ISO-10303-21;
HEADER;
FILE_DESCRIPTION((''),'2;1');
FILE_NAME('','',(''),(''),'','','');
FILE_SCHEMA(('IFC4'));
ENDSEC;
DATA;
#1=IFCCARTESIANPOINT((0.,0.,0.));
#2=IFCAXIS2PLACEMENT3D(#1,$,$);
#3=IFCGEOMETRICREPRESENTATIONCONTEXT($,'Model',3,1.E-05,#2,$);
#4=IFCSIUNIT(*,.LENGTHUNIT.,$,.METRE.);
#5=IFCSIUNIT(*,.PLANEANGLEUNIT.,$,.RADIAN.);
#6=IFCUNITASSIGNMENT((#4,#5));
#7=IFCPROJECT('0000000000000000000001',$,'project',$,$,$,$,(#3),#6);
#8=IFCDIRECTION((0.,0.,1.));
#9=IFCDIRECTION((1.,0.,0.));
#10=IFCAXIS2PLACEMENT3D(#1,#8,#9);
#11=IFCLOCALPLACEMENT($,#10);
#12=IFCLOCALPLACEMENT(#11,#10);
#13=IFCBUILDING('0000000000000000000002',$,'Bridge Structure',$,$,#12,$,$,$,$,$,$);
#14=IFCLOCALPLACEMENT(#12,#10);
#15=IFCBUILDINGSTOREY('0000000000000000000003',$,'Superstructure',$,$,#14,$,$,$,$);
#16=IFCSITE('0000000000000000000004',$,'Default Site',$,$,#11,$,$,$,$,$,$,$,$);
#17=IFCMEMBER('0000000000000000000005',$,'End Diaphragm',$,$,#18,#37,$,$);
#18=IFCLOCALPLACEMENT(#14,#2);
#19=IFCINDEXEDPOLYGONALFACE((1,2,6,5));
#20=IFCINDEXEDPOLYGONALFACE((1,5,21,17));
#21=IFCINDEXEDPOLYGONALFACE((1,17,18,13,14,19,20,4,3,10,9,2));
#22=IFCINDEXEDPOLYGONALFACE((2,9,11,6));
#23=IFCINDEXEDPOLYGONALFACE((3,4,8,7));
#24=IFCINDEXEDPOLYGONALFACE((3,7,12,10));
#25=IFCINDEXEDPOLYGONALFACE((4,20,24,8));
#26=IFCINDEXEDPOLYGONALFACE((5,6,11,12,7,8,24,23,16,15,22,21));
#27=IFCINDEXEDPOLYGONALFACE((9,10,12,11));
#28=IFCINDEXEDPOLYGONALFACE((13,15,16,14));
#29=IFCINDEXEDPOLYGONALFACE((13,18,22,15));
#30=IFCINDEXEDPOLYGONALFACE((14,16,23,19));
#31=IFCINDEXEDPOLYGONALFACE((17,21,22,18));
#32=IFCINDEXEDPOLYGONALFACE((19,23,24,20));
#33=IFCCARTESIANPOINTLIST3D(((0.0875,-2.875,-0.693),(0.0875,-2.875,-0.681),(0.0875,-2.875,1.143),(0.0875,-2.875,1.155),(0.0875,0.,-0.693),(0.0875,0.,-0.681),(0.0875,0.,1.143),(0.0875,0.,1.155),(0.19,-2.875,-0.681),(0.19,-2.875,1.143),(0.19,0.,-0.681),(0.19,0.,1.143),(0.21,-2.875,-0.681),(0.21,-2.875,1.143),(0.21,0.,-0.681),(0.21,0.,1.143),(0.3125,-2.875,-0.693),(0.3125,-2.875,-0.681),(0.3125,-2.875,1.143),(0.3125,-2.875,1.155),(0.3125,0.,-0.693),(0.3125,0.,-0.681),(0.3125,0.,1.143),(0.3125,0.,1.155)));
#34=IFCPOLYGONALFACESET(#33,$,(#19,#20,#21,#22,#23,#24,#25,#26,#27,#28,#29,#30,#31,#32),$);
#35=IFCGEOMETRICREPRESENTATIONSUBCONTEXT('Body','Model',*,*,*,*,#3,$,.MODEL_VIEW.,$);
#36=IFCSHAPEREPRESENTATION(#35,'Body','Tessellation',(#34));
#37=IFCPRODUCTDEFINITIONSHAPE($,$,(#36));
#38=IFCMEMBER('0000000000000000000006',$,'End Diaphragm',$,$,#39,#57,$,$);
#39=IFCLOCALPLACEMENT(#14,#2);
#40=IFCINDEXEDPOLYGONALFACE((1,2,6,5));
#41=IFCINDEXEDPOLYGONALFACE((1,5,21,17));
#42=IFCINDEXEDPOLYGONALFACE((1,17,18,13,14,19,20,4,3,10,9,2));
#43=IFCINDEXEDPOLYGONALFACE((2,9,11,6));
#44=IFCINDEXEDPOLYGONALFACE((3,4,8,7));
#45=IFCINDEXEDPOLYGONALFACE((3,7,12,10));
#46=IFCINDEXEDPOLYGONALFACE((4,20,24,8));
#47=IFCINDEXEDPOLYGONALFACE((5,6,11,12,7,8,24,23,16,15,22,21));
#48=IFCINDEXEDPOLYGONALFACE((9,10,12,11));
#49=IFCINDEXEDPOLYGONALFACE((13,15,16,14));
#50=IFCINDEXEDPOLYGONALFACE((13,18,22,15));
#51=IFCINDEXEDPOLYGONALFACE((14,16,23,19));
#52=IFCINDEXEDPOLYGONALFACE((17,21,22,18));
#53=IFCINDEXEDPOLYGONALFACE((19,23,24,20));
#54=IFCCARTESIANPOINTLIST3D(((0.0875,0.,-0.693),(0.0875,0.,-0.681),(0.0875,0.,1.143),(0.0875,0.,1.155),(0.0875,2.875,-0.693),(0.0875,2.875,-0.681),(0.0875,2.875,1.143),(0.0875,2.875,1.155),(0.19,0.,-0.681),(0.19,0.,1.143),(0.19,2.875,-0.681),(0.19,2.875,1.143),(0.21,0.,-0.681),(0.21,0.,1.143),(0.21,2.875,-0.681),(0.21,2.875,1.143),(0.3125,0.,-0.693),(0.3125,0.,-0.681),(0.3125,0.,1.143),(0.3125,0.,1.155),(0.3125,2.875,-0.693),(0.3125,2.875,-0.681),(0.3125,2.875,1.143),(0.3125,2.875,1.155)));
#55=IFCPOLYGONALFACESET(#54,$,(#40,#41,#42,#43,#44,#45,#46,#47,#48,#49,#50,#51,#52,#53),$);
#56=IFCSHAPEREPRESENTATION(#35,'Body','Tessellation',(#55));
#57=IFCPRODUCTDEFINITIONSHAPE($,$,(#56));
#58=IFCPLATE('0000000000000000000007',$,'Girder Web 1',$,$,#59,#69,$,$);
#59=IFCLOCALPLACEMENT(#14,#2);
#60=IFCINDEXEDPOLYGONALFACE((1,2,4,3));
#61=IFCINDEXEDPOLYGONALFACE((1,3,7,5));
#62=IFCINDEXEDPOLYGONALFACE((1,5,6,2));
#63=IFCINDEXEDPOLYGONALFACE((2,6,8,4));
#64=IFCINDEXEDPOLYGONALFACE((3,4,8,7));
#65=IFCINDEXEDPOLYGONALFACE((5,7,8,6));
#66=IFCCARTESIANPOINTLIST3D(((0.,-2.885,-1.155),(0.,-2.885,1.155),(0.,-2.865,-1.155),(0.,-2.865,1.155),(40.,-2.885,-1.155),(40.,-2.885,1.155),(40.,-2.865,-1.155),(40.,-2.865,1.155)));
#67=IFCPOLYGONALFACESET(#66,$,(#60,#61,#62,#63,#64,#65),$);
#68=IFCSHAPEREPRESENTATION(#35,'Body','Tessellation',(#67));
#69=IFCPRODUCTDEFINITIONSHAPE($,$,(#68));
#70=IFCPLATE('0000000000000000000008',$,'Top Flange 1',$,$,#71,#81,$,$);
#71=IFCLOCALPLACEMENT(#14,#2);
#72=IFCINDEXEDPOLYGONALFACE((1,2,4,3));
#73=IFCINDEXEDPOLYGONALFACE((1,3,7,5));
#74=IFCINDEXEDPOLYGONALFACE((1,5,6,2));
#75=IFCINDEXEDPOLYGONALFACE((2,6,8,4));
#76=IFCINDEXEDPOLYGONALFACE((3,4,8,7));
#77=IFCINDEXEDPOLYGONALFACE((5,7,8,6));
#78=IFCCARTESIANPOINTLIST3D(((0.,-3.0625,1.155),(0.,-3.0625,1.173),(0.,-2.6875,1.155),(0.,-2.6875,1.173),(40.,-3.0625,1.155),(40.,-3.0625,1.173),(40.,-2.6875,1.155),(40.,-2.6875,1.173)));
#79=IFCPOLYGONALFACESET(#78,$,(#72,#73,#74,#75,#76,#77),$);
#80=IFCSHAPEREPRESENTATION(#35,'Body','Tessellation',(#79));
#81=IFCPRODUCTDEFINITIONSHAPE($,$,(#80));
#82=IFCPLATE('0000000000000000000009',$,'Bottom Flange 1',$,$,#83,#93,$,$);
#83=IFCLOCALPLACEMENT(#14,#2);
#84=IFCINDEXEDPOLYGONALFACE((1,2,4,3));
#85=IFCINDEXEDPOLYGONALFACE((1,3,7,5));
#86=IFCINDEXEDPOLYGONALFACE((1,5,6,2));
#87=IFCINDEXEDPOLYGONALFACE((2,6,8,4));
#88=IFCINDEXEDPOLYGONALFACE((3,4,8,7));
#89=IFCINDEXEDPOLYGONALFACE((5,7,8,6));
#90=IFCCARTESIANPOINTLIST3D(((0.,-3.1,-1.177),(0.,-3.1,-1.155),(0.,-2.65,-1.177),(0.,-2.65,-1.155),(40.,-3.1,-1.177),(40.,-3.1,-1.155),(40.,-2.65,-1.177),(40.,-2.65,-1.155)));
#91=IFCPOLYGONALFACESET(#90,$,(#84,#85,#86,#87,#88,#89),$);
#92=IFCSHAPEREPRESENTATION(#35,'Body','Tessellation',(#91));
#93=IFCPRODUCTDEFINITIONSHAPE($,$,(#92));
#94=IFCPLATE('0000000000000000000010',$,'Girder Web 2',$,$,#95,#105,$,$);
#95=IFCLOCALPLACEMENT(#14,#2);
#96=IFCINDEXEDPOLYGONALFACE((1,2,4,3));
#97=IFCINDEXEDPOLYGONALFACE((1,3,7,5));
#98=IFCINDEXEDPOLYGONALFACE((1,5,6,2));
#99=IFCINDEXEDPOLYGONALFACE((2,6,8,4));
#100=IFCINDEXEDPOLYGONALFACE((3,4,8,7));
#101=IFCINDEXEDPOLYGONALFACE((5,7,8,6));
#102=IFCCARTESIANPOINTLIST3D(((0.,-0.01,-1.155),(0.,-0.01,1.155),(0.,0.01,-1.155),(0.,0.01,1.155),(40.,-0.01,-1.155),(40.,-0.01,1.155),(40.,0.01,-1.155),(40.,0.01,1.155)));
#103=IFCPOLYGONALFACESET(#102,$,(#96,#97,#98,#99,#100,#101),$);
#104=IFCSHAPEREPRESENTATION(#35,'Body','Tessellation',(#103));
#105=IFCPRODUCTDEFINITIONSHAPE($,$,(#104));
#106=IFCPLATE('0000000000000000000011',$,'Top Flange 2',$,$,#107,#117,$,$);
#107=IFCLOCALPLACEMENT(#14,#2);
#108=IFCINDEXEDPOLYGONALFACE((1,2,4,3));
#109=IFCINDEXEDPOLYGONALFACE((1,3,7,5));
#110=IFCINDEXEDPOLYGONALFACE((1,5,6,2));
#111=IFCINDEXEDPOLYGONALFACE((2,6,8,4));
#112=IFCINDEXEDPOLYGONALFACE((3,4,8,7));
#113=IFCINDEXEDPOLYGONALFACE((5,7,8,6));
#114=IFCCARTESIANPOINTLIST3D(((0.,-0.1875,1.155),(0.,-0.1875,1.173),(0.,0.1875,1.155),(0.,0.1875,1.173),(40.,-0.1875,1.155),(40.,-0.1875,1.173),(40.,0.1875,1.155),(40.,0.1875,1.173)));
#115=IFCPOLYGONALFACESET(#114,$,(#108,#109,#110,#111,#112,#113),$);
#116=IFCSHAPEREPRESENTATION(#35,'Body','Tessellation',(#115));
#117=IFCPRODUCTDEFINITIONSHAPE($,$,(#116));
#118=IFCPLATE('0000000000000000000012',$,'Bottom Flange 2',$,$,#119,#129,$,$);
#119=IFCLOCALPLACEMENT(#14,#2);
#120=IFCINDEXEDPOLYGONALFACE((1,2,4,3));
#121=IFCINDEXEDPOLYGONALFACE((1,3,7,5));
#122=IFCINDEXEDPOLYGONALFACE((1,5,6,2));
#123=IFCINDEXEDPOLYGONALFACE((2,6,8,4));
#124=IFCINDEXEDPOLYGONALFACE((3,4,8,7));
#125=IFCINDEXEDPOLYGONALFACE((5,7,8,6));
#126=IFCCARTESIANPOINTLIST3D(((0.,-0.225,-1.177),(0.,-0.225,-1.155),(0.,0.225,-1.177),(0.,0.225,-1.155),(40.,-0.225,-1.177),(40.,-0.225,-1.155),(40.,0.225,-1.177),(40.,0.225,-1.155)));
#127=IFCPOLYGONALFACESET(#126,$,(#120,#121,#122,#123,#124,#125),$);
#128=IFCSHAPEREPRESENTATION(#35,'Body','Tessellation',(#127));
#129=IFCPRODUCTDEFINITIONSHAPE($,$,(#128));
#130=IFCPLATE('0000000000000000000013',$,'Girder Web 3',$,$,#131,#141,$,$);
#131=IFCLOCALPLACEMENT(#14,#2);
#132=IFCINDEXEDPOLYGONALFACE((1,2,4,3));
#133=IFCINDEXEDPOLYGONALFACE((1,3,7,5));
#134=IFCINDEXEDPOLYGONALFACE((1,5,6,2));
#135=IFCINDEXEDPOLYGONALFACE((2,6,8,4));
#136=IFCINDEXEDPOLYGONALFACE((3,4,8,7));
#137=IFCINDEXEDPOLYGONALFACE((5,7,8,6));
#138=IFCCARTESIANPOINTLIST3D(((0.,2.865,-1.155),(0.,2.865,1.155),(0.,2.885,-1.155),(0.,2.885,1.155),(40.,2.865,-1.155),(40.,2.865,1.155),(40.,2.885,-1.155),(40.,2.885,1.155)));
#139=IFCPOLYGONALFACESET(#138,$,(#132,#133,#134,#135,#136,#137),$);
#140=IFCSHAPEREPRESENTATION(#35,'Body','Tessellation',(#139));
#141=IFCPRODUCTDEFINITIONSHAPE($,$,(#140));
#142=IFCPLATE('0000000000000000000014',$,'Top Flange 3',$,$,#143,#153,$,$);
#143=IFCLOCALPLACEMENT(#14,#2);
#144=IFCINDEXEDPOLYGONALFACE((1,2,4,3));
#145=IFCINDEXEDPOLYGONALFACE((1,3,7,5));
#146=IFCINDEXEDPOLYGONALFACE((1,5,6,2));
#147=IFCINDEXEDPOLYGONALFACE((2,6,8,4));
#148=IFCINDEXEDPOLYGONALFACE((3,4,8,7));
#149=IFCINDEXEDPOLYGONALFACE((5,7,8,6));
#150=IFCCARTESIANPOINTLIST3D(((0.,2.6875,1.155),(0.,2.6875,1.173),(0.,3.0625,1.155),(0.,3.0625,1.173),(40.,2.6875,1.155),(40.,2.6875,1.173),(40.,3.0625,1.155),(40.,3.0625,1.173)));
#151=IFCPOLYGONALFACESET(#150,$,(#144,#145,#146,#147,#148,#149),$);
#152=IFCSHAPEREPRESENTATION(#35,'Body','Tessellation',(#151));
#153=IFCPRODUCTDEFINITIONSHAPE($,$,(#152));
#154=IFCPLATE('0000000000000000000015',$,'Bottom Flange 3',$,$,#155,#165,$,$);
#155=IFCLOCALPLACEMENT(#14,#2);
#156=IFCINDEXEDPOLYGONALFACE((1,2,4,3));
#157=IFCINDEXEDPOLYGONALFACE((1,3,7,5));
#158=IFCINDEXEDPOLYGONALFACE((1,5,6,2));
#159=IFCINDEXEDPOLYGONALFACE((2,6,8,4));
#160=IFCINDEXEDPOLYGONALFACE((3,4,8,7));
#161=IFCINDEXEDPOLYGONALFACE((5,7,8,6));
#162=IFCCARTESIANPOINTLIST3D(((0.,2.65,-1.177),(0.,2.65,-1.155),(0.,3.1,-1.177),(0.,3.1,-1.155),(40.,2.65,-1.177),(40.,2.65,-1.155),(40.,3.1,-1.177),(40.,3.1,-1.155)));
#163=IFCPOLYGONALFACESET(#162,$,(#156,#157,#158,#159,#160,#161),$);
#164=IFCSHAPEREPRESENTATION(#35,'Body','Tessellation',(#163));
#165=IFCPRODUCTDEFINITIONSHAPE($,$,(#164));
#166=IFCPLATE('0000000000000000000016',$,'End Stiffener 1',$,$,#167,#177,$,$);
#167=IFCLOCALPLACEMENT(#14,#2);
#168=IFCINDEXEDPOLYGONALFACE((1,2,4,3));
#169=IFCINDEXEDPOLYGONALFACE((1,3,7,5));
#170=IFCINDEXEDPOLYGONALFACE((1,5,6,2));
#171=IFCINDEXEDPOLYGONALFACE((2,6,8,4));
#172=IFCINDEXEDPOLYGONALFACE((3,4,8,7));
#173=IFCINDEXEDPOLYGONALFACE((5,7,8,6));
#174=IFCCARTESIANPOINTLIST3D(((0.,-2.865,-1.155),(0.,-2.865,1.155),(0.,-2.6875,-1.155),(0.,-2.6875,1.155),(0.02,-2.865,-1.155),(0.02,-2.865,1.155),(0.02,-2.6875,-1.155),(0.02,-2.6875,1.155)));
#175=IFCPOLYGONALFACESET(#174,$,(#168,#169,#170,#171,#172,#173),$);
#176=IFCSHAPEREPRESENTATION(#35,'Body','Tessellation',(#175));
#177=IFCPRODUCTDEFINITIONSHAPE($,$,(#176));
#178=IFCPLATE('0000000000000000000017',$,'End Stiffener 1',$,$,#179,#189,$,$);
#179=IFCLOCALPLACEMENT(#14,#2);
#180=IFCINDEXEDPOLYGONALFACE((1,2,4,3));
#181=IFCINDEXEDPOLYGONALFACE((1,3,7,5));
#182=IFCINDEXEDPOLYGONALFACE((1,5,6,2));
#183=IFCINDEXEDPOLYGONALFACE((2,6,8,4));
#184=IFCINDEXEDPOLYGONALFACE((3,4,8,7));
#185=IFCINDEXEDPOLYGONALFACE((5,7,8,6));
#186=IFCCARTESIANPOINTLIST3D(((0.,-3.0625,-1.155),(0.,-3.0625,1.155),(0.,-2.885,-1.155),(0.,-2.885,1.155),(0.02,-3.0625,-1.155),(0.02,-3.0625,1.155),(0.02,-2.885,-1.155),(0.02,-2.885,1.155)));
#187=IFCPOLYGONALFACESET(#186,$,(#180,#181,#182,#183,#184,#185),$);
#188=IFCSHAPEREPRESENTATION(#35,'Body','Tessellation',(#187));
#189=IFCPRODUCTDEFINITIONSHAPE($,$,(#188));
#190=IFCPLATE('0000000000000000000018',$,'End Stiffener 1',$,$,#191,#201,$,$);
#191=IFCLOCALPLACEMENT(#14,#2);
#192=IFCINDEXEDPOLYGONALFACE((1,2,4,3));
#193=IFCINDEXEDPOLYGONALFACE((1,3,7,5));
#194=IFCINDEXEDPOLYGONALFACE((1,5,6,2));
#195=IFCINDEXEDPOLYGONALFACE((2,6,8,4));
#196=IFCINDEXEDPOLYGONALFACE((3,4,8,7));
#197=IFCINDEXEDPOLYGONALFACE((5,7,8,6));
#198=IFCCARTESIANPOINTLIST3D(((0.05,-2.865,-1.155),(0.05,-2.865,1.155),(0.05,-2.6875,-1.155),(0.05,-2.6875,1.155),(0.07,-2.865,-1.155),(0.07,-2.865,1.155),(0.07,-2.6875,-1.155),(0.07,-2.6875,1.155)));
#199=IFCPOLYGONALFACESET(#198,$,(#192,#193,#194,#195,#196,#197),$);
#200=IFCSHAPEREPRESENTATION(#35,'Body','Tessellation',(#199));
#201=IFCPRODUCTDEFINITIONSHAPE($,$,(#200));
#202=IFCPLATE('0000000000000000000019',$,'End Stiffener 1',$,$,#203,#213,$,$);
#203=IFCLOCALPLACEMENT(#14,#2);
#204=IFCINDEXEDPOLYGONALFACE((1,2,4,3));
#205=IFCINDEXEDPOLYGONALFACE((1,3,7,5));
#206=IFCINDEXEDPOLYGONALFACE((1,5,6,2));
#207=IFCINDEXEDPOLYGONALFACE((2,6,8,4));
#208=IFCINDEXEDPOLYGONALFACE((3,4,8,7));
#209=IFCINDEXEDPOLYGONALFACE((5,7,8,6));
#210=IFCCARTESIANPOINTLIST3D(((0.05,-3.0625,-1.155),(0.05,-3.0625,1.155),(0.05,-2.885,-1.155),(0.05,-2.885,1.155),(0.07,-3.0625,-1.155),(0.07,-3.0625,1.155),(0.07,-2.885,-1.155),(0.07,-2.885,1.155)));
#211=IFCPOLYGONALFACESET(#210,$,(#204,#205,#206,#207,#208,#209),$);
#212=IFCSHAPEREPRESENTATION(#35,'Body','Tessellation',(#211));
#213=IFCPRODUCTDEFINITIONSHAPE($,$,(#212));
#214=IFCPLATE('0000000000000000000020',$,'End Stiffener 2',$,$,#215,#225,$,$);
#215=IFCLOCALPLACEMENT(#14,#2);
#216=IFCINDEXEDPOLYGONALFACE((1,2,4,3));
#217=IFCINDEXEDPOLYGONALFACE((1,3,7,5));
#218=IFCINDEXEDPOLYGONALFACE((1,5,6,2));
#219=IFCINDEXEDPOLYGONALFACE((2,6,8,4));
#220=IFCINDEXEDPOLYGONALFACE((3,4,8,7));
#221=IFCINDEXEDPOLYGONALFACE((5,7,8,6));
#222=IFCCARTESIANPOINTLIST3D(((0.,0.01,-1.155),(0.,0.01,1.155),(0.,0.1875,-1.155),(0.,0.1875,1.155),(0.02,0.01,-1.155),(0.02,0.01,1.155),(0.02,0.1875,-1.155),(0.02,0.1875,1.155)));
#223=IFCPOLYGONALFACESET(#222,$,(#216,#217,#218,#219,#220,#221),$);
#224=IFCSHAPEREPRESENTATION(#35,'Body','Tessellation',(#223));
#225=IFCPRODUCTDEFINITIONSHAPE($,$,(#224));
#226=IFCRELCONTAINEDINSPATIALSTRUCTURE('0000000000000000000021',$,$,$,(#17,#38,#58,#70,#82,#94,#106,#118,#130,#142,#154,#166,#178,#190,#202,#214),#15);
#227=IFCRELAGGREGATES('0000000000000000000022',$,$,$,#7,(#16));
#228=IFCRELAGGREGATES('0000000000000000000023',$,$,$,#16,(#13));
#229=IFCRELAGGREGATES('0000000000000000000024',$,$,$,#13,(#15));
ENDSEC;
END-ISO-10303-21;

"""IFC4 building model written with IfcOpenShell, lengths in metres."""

from ifc_helpers import new_model, si_unit, frame, origin, origin_with_axes, origin_2d_with_axis, place, context, subcontext, project, spatial, rectangle, i_section, extrude, element, save


model = new_model("IFC4")

# Units and contexts
model_context = context("Model", 3, precision=1e-05, world=origin())
body_context = subcontext(model_context, "Body", "Model", "MODEL_VIEW")
ifc_project = project(units=[si_unit("LENGTHUNIT", "METRE"), si_unit("PLANEANGLEUNIT", "RADIAN")], contexts=[model_context])

# Site, building, storey
site_placement = place(None, origin_with_axes())
site = spatial("IfcSite", under=ifc_project, at=site_placement, Name="Default Site")
building_placement = place(site_placement, origin_with_axes())
building = spatial("IfcBuilding", under=site, at=building_placement, Name="Bridge Structure")
storey_placement = place(building_placement, origin_with_axes())
storey = spatial("IfcBuildingStorey", under=building, at=storey_placement, Name="Superstructure")

# Members
for number, where, z_axis, x_axis, name in (
    (1, (0.2, -2.875, 0.231), (0.0, 1.0, 0.0), (-1.0, 0.0, 0.0), "End Diaphragm"),
    (2, (0.2, 0.0, 0.231), (0.0, 1.0, 0.0), (-1.0, 0.0, 0.0), "End Diaphragm"),
):
    element("IfcMember", number, at=place(storey_placement, frame(where, z_axis=z_axis, x_axis=x_axis)), inside=storey, Name=name, context=body_context, shape_type="SweptSolid", body=[
        extrude(i_section(OverallWidth=0.225, OverallDepth=1.848, WebThickness=0.02, FlangeThickness=0.012, at=origin_2d_with_axis()), origin_with_axes(), (0.0, 0.0, 1.0), 2.875),
    ])

# Plates
plate_1_placement = place(storey_placement, frame((0.0, -2.875, 0.0), z_axis=(1.0, 0.0, 0.0), x_axis=(0.0, 1.0, 0.0)))
element("IfcPlate", 3, at=plate_1_placement, inside=storey, Name="Girder Web 1", context=body_context, shape_type="SweptSolid", body=[
    extrude(rectangle(XDim=0.02, YDim=2.31, at=origin_2d_with_axis()), origin_with_axes(), (0.0, 0.0, 1.0), 40.0),
])
plate_2_placement = place(storey_placement, frame((0.0, -2.875, 1.164), z_axis=(1.0, 0.0, 0.0), x_axis=(0.0, 1.0, 0.0)))
element("IfcPlate", 4, at=plate_2_placement, inside=storey, Name="Top Flange 1", context=body_context, shape_type="SweptSolid", body=[
    extrude(rectangle(XDim=0.375, YDim=0.018, at=origin_2d_with_axis()), origin_with_axes(), (0.0, 0.0, 1.0), 40.0),
])
plate_3_placement = place(storey_placement, frame((0.0, -2.875, -1.166), z_axis=(1.0, 0.0, 0.0), x_axis=(0.0, 1.0, 0.0)))
element("IfcPlate", 5, at=plate_3_placement, inside=storey, Name="Bottom Flange 1", context=body_context, shape_type="SweptSolid", body=[
    extrude(rectangle(XDim=0.45, YDim=0.022, at=origin_2d_with_axis()), origin_with_axes(), (0.0, 0.0, 1.0), 40.0),
])
plate_4_placement = place(storey_placement, frame((0.0, 0.0, 0.0), z_axis=(1.0, 0.0, 0.0), x_axis=(0.0, 1.0, 0.0)))
element("IfcPlate", 6, at=plate_4_placement, inside=storey, Name="Girder Web 2", context=body_context, shape_type="SweptSolid", body=[
    extrude(rectangle(XDim=0.02, YDim=2.31, at=origin_2d_with_axis()), origin_with_axes(), (0.0, 0.0, 1.0), 40.0),
])
plate_5_placement = place(storey_placement, frame((0.0, 0.0, 1.164), z_axis=(1.0, 0.0, 0.0), x_axis=(0.0, 1.0, 0.0)))
element("IfcPlate", 7, at=plate_5_placement, inside=storey, Name="Top Flange 2", context=body_context, shape_type="SweptSolid", body=[
    extrude(rectangle(XDim=0.375, YDim=0.018, at=origin_2d_with_axis()), origin_with_axes(), (0.0, 0.0, 1.0), 40.0),
])
plate_6_placement = place(storey_placement, frame((0.0, 0.0, -1.166), z_axis=(1.0, 0.0, 0.0), x_axis=(0.0, 1.0, 0.0)))
element("IfcPlate", 8, at=plate_6_placement, inside=storey, Name="Bottom Flange 2", context=body_context, shape_type="SweptSolid", body=[
    extrude(rectangle(XDim=0.45, YDim=0.022, at=origin_2d_with_axis()), origin_with_axes(), (0.0, 0.0, 1.0), 40.0),
])
plate_7_placement = place(storey_placement, frame((0.0, 2.875, 0.0), z_axis=(1.0, 0.0, 0.0), x_axis=(0.0, 1.0, 0.0)))
element("IfcPlate", 9, at=plate_7_placement, inside=storey, Name="Girder Web 3", context=body_context, shape_type="SweptSolid", body=[
    extrude(rectangle(XDim=0.02, YDim=2.31, at=origin_2d_with_axis()), origin_with_axes(), (0.0, 0.0, 1.0), 40.0),
])
plate_8_placement = place(storey_placement, frame((0.0, 2.875, 1.164), z_axis=(1.0, 0.0, 0.0), x_axis=(0.0, 1.0, 0.0)))
element("IfcPlate", 10, at=plate_8_placement, inside=storey, Name="Top Flange 3", context=body_context, shape_type="SweptSolid", body=[
    extrude(rectangle(XDim=0.375, YDim=0.018, at=origin_2d_with_axis()), origin_with_axes(), (0.0, 0.0, 1.0), 40.0),
])
plate_9_placement = place(storey_placement, frame((0.0, 2.875, -1.166), z_axis=(1.0, 0.0, 0.0), x_axis=(0.0, 1.0, 0.0)))
element("IfcPlate", 11, at=plate_9_placement, inside=storey, Name="Bottom Flange 3", context=body_context, shape_type="SweptSolid", body=[
    extrude(rectangle(XDim=0.45, YDim=0.022, at=origin_2d_with_axis()), origin_with_axes(), (0.0, 0.0, 1.0), 40.0),
])
for number, where, z_axis, x_axis, name in (
    (12, (0.01, -2.7763, -1.155), (0.0, 0.0, 1.0), (1.0, 0.0, 0.0), "End Stiffener 1"),
    (13, (0.01, -2.9737, -1.155), (0.0, 0.0, 1.0), (1.0, 0.0, 0.0), "End Stiffener 1"),
    (14, (0.06, -2.7763, -1.155), (0.0, 0.0, 1.0), (1.0, 0.0, 0.0), "End Stiffener 1"),
    (15, (0.06, -2.9737, -1.155), (0.0, 0.0, 1.0), (1.0, 0.0, 0.0), "End Stiffener 1"),
    (16, (0.01, 0.0988, -1.155), (0.0, 0.0, 1.0), (1.0, 0.0, 0.0), "End Stiffener 2"),
):
    element("IfcPlate", number, at=place(storey_placement, frame(where, z_axis=z_axis, x_axis=x_axis)), inside=storey, Name=name, context=body_context, shape_type="SweptSolid", body=[
        extrude(rectangle(XDim=0.02, YDim=0.1775, at=origin_2d_with_axis()), origin_with_axes(), (0.0, 0.0, 1.0), 2.31),
    ])

save(model, "model.ifc")
